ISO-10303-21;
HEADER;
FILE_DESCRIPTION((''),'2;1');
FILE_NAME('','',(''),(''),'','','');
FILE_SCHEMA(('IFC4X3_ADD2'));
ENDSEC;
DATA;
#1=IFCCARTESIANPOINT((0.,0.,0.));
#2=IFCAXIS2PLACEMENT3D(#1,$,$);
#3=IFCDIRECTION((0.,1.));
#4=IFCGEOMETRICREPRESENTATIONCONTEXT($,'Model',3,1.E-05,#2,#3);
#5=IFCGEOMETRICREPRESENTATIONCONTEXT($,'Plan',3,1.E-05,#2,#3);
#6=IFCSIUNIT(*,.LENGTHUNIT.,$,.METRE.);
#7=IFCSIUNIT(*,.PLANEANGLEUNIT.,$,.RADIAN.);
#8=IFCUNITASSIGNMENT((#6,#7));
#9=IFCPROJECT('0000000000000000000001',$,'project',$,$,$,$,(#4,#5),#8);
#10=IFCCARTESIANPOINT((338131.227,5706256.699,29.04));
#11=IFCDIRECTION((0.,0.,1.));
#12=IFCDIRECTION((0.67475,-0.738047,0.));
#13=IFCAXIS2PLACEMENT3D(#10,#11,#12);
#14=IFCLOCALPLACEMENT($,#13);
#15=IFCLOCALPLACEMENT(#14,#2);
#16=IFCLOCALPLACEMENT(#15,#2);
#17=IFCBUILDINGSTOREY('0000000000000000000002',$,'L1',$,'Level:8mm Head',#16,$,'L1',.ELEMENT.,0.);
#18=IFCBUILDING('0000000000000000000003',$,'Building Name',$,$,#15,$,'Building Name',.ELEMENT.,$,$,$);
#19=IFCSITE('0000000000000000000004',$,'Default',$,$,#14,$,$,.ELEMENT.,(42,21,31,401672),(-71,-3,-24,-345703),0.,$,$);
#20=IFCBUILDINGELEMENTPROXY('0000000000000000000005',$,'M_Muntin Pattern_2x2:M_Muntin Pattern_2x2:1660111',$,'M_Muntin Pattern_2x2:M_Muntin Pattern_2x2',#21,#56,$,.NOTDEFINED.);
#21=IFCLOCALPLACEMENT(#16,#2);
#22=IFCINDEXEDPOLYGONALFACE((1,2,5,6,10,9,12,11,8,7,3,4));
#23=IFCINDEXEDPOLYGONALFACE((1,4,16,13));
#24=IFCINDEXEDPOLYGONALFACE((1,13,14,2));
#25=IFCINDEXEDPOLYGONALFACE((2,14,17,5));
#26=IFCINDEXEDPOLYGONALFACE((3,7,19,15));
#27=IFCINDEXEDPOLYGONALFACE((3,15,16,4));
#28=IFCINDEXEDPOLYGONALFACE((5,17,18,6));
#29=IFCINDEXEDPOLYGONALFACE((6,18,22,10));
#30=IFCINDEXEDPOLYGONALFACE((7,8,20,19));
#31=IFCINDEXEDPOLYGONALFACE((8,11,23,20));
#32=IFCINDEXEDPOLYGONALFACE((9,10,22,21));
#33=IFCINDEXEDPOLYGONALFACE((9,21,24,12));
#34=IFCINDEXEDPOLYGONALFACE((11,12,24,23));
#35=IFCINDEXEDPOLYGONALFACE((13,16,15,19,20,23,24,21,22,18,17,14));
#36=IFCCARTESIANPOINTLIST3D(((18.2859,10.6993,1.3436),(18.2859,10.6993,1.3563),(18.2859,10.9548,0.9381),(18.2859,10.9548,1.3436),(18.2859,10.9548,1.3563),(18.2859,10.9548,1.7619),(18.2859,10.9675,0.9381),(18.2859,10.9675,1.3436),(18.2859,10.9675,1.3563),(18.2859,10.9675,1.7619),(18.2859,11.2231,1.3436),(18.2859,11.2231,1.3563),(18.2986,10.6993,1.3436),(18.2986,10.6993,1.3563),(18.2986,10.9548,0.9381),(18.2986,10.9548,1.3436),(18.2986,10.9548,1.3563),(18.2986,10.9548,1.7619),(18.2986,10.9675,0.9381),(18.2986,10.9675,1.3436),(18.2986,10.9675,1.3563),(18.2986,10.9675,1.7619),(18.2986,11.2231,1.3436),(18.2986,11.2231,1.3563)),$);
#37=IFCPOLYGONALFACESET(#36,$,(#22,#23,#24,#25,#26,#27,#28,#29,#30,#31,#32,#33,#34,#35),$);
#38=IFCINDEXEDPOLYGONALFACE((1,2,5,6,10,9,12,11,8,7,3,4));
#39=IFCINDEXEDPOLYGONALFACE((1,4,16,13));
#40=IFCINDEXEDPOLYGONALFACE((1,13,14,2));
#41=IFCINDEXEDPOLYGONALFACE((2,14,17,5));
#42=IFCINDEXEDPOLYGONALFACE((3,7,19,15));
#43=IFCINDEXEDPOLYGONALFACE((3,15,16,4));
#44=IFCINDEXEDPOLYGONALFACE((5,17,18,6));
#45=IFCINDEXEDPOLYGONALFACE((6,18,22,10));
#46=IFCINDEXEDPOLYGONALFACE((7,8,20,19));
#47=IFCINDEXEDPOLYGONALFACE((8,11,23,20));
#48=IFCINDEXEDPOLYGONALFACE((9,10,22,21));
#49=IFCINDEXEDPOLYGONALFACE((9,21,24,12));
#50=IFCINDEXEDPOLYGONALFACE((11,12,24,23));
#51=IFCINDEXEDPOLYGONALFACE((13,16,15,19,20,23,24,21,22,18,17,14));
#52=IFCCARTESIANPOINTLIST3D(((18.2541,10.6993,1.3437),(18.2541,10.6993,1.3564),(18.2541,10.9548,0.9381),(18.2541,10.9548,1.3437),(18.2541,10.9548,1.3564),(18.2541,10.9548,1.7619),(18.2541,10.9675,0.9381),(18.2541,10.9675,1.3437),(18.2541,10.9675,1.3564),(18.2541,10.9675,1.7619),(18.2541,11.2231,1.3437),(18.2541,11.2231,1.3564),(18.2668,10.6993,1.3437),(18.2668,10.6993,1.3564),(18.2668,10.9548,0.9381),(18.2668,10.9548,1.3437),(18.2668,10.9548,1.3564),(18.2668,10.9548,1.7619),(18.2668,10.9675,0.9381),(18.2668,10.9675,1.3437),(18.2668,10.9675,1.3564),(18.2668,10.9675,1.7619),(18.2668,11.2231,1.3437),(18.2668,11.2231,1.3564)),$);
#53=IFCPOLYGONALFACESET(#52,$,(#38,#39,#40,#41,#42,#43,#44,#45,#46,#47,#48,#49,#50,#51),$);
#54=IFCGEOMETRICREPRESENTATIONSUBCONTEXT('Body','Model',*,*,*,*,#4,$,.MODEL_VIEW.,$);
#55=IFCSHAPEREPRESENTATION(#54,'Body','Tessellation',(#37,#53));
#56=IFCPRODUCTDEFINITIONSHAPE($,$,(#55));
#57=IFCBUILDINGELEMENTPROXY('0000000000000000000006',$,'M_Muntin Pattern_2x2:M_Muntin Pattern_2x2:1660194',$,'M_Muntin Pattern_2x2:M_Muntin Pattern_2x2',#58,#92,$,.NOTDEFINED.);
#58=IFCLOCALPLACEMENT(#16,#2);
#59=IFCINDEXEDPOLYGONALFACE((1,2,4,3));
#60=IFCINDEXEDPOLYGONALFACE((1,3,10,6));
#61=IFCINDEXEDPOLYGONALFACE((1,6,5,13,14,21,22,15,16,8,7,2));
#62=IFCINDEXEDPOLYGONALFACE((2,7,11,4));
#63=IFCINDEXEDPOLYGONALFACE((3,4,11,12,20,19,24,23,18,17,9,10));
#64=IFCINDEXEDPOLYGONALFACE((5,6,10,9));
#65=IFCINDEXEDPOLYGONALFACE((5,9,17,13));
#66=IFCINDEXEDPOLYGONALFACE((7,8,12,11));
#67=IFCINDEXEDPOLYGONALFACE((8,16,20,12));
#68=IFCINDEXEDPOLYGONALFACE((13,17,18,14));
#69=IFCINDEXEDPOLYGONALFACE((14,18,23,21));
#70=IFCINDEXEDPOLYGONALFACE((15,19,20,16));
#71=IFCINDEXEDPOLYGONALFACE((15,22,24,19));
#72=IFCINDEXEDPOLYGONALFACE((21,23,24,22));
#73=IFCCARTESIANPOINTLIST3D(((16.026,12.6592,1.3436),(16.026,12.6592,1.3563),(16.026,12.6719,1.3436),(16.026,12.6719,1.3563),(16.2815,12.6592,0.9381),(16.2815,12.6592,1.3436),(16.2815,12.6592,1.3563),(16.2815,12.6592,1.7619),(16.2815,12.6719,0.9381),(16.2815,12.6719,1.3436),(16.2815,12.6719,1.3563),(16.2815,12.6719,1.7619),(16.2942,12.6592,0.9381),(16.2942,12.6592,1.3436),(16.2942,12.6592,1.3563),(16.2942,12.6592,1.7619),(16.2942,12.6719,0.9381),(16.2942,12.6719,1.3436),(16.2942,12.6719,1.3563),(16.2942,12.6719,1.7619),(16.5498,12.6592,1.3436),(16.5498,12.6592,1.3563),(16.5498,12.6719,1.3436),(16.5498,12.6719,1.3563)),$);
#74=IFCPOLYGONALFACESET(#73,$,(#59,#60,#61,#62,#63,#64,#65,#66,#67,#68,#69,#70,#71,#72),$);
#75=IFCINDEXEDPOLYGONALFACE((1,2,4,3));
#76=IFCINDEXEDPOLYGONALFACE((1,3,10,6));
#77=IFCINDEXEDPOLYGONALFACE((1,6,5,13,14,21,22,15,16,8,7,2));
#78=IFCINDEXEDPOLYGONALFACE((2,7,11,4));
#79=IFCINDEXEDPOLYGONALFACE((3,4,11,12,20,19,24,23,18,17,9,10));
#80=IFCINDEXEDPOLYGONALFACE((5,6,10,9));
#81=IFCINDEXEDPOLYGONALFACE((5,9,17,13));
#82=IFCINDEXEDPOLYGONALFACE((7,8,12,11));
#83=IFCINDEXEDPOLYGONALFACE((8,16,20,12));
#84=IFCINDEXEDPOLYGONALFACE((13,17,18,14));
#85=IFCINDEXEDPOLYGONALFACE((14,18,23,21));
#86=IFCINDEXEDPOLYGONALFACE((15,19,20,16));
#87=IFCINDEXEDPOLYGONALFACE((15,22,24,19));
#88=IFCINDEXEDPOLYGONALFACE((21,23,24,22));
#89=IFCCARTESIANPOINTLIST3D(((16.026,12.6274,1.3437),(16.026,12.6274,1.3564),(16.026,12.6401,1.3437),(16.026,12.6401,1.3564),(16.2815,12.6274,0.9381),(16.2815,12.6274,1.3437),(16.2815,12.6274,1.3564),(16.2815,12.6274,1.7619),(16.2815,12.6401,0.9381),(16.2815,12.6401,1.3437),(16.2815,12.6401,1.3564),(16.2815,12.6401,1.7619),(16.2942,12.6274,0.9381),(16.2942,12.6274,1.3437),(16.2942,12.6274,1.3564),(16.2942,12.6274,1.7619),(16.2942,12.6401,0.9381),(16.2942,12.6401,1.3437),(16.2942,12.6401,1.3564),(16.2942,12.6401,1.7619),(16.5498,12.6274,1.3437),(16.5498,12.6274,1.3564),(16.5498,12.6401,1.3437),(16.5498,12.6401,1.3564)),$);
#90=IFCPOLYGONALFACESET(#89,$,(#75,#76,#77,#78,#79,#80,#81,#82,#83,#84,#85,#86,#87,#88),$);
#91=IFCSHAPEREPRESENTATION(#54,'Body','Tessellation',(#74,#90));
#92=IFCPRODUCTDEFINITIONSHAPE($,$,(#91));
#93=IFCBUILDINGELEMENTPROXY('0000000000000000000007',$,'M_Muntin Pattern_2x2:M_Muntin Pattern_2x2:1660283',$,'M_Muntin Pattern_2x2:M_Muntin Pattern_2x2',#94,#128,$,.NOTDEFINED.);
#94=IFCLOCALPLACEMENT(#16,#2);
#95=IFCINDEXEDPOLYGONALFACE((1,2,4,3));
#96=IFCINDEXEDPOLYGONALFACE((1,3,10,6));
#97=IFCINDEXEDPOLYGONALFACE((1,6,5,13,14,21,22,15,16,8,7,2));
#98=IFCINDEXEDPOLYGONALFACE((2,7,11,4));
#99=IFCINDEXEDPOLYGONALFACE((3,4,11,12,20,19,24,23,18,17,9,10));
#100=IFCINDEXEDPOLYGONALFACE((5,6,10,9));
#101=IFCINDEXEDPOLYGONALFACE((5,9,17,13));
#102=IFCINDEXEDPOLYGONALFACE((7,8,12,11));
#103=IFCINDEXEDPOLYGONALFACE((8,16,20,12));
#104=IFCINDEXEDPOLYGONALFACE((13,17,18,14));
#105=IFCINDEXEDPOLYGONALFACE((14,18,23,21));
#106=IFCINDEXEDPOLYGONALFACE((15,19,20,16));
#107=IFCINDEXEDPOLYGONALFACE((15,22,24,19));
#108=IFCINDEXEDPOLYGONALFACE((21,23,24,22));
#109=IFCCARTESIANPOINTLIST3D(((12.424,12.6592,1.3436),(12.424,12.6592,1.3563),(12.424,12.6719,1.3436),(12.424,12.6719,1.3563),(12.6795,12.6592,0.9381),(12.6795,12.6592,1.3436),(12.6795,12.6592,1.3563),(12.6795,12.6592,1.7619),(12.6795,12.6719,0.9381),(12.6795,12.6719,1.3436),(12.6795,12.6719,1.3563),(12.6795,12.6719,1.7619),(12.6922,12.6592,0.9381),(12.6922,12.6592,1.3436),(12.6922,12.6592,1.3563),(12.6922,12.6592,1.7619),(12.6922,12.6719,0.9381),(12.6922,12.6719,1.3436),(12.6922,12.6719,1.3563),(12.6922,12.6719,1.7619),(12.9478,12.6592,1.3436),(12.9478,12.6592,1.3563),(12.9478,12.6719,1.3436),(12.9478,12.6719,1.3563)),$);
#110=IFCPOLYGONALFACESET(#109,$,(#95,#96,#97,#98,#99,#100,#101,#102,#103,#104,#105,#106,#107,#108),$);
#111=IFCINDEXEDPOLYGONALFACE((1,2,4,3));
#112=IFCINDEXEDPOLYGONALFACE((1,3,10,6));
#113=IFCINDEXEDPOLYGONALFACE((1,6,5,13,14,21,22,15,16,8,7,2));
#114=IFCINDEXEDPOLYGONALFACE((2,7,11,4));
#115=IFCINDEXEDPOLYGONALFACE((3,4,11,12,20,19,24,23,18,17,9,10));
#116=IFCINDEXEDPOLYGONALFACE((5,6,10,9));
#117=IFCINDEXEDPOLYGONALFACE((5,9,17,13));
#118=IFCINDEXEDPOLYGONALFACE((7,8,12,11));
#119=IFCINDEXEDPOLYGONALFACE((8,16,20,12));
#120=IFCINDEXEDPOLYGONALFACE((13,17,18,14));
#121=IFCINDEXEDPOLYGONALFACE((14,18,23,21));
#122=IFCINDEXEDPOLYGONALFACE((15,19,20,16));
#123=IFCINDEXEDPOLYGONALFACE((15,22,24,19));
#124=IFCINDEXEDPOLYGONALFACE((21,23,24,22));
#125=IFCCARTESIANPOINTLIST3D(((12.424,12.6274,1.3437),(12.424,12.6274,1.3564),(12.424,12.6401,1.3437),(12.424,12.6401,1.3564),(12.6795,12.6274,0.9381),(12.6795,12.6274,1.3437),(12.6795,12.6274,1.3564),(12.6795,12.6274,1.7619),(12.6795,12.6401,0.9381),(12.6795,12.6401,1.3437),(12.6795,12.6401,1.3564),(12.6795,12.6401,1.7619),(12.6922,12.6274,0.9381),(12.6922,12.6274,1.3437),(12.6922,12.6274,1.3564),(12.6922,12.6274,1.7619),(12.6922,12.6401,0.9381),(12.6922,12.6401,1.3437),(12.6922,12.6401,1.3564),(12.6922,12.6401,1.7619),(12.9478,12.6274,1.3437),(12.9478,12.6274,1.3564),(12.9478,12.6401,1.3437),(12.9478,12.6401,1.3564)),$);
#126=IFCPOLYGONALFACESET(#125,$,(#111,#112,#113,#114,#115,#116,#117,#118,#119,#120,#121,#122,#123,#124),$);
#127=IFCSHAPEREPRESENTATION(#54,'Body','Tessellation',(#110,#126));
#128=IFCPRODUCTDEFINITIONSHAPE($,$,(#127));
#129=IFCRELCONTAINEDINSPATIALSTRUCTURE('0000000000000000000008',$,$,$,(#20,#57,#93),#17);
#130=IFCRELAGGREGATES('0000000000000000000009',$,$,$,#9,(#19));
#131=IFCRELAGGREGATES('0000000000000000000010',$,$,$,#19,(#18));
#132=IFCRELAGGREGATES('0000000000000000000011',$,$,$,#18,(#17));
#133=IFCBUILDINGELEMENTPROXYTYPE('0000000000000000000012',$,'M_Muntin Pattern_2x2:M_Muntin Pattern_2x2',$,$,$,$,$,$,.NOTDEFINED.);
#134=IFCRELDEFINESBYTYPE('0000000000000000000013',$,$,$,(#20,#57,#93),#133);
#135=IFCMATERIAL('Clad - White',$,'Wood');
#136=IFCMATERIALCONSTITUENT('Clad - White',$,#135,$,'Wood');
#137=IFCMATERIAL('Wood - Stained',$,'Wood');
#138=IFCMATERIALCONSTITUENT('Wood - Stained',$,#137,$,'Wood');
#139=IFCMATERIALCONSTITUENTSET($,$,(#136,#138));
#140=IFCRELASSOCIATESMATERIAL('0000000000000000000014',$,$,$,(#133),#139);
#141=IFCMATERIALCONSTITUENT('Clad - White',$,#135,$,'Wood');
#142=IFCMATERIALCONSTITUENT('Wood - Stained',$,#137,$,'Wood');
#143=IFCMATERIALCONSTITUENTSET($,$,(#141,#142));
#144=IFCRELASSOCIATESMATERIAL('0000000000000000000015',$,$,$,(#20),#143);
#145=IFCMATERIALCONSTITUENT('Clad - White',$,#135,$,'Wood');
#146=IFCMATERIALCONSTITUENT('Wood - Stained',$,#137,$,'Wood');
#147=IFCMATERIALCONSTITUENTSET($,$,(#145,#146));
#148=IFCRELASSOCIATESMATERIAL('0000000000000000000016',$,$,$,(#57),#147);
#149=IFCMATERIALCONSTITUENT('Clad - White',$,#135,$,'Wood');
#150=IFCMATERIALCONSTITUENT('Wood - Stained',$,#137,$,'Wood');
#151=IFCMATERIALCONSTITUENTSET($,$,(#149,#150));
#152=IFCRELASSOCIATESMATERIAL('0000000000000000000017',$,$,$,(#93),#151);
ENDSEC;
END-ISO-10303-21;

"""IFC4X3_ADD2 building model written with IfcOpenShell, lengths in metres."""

from ifc_helpers import new_model, si_unit, direction, frame, origin, place, context, subcontext, project, spatial, polyline, outline, extrude, source, transform, mapped, material, constituent, constituent_set, type_object, type_shapes, element, save


model = new_model("IFC4X3_ADD2")

# Units and contexts
model_context = context("Model", 3, precision=1e-05, world=origin(), true_north=direction((0.0, 1.0)))
plan_context = context("Plan", 3, precision=1e-05, world=origin(), true_north=direction((0.0, 1.0)))
body_context = subcontext(model_context, "Body", "Model", "MODEL_VIEW")
ifc_project = project(units=[si_unit("LENGTHUNIT", "METRE"), si_unit("PLANEANGLEUNIT", "RADIAN")], contexts=[model_context, plan_context])

# Site, building, storey
site_placement = place(None, frame((338131.227, 5706256.699, 29.04), z_axis=(0.0, 0.0, 1.0), x_axis=(0.67475, -0.738047, 0.0)))
site = spatial("IfcSite", under=ifc_project, at=site_placement, Name="Default", CompositionType="ELEMENT", RefLatitude=(42, 21, 31, 401672), RefLongitude=(-71, -3, -24, -345703), RefElevation=0.0)
building_placement = place(site_placement, origin())
building = spatial("IfcBuilding", under=site, at=building_placement, Name="Building Name", LongName="Building Name", CompositionType="ELEMENT")
storey_placement = place(building_placement, origin())
storey = spatial("IfcBuildingStorey", under=building, at=storey_placement, Name="L1", ObjectType="Level:8mm Head", LongName="L1", CompositionType="ELEMENT", Elevation=0.0)

# Building element proxies
ifc_material_1 = material(Name="Clad - White", Category="Wood")
ifc_material_2 = material(Name="Wood - Stained", Category="Wood")
ifc_constituent_1 = constituent(ifc_material_1, Name="Clad - White", Category="Wood")
ifc_constituent_2 = constituent(ifc_material_2, Name="Wood - Stained", Category="Wood")
ifc_constituent_set_1 = constituent_set(constituents=[ifc_constituent_1, ifc_constituent_2])
building_element_proxy_type = type_object("IfcBuildingElementProxyType", Name="M_Muntin Pattern_2x2:M_Muntin Pattern_2x2", PredefinedType="NOTDEFINED", material=ifc_constituent_set_1)
shared_shape = source(origin(), body_context, "Body", "SweptSolid", [
    extrude(outline(polyline([(0.0064, -0.0064), (0.4119, -0.0064), (0.4119, 0.0063), (0.0064, 0.0063), (0.0064, 0.2619), (-0.0063, 0.2619), (-0.0063, 0.0063), (-0.4119, 0.0063), (-0.4119, -0.0064), (-0.0063, -0.0064), (-0.0063, -0.2619), (0.0064, -0.2619), (0.0064, -0.0064)])), frame((0.0, -0.0222, 0.4119), z_axis=(0.0, 1.0, 0.0), x_axis=(0.0, 0.0, 1.0)), (0.0, 0.0, 1.0), 0.0127),
    extrude(outline(polyline([(0.0064, -0.0064), (0.4119, -0.0064), (0.4119, 0.0063), (0.0064, 0.0063), (0.0064, 0.2619), (-0.0063, 0.2619), (-0.0063, 0.0063), (-0.4119, 0.0063), (-0.4119, -0.0064), (-0.0063, -0.0064), (-0.0063, -0.2619), (0.0064, -0.2619), (0.0064, -0.0064)])), frame((0.0, 0.0095, 0.4119), z_axis=(0.0, 1.0, 0.0), x_axis=(0.0, 0.0, 1.0)), (0.0, 0.0, 1.0), 0.0127),
])
type_shapes(building_element_proxy_type, [shared_shape])
ifc_constituent_3 = constituent(ifc_material_1, Name="Clad - White", Category="Wood")
ifc_constituent_4 = constituent(ifc_material_2, Name="Wood - Stained", Category="Wood")
ifc_constituent_set_2 = constituent_set(constituents=[ifc_constituent_3, ifc_constituent_4])
proxy_1_placement = place(storey_placement, frame((18.2763, 10.9612, 0.9381), z_axis=(0.0, 0.0, 1.0), x_axis=(0.0, 1.0, 0.0)))
element("IfcBuildingElementProxy", 1, at=proxy_1_placement, inside=storey, type_object=building_element_proxy_type, material=ifc_constituent_set_2, Name="M_Muntin Pattern_2x2:M_Muntin Pattern_2x2:1660111", ObjectType="M_Muntin Pattern_2x2:M_Muntin Pattern_2x2", PredefinedType="NOTDEFINED", context=body_context, shape_type="MappedRepresentation", body=[
    mapped(shared_shape, transform((0.0, 0.0, 0.0), scale=1.0)),
])
ifc_constituent_5 = constituent(ifc_material_1, Name="Clad - White", Category="Wood")
ifc_constituent_6 = constituent(ifc_material_2, Name="Wood - Stained", Category="Wood")
ifc_constituent_set_3 = constituent_set(constituents=[ifc_constituent_5, ifc_constituent_6])
proxy_2_placement = place(storey_placement, frame((16.2879, 12.6497, 0.9381), z_axis=(0.0, 0.0, 1.0), x_axis=(-1.0, 0.0, 0.0)))
element("IfcBuildingElementProxy", 2, at=proxy_2_placement, inside=storey, type_object=building_element_proxy_type, material=ifc_constituent_set_3, Name="M_Muntin Pattern_2x2:M_Muntin Pattern_2x2:1660194", ObjectType="M_Muntin Pattern_2x2:M_Muntin Pattern_2x2", PredefinedType="NOTDEFINED", context=body_context, shape_type="MappedRepresentation", body=[
    mapped(shared_shape, transform((0.0, 0.0, 0.0), scale=1.0)),
])
ifc_constituent_7 = constituent(ifc_material_1, Name="Clad - White", Category="Wood")
ifc_constituent_8 = constituent(ifc_material_2, Name="Wood - Stained", Category="Wood")
ifc_constituent_set_4 = constituent_set(constituents=[ifc_constituent_7, ifc_constituent_8])
proxy_3_placement = place(storey_placement, frame((12.6859, 12.6497, 0.9381), z_axis=(0.0, 0.0, 1.0), x_axis=(-1.0, 0.0, 0.0)))
element("IfcBuildingElementProxy", 3, at=proxy_3_placement, inside=storey, type_object=building_element_proxy_type, material=ifc_constituent_set_4, Name="M_Muntin Pattern_2x2:M_Muntin Pattern_2x2:1660283", ObjectType="M_Muntin Pattern_2x2:M_Muntin Pattern_2x2", PredefinedType="NOTDEFINED", context=body_context, shape_type="MappedRepresentation", body=[
    mapped(shared_shape, transform((0.0, 0.0, 0.0), scale=1.0)),
])

save(model, "model.ifc")
